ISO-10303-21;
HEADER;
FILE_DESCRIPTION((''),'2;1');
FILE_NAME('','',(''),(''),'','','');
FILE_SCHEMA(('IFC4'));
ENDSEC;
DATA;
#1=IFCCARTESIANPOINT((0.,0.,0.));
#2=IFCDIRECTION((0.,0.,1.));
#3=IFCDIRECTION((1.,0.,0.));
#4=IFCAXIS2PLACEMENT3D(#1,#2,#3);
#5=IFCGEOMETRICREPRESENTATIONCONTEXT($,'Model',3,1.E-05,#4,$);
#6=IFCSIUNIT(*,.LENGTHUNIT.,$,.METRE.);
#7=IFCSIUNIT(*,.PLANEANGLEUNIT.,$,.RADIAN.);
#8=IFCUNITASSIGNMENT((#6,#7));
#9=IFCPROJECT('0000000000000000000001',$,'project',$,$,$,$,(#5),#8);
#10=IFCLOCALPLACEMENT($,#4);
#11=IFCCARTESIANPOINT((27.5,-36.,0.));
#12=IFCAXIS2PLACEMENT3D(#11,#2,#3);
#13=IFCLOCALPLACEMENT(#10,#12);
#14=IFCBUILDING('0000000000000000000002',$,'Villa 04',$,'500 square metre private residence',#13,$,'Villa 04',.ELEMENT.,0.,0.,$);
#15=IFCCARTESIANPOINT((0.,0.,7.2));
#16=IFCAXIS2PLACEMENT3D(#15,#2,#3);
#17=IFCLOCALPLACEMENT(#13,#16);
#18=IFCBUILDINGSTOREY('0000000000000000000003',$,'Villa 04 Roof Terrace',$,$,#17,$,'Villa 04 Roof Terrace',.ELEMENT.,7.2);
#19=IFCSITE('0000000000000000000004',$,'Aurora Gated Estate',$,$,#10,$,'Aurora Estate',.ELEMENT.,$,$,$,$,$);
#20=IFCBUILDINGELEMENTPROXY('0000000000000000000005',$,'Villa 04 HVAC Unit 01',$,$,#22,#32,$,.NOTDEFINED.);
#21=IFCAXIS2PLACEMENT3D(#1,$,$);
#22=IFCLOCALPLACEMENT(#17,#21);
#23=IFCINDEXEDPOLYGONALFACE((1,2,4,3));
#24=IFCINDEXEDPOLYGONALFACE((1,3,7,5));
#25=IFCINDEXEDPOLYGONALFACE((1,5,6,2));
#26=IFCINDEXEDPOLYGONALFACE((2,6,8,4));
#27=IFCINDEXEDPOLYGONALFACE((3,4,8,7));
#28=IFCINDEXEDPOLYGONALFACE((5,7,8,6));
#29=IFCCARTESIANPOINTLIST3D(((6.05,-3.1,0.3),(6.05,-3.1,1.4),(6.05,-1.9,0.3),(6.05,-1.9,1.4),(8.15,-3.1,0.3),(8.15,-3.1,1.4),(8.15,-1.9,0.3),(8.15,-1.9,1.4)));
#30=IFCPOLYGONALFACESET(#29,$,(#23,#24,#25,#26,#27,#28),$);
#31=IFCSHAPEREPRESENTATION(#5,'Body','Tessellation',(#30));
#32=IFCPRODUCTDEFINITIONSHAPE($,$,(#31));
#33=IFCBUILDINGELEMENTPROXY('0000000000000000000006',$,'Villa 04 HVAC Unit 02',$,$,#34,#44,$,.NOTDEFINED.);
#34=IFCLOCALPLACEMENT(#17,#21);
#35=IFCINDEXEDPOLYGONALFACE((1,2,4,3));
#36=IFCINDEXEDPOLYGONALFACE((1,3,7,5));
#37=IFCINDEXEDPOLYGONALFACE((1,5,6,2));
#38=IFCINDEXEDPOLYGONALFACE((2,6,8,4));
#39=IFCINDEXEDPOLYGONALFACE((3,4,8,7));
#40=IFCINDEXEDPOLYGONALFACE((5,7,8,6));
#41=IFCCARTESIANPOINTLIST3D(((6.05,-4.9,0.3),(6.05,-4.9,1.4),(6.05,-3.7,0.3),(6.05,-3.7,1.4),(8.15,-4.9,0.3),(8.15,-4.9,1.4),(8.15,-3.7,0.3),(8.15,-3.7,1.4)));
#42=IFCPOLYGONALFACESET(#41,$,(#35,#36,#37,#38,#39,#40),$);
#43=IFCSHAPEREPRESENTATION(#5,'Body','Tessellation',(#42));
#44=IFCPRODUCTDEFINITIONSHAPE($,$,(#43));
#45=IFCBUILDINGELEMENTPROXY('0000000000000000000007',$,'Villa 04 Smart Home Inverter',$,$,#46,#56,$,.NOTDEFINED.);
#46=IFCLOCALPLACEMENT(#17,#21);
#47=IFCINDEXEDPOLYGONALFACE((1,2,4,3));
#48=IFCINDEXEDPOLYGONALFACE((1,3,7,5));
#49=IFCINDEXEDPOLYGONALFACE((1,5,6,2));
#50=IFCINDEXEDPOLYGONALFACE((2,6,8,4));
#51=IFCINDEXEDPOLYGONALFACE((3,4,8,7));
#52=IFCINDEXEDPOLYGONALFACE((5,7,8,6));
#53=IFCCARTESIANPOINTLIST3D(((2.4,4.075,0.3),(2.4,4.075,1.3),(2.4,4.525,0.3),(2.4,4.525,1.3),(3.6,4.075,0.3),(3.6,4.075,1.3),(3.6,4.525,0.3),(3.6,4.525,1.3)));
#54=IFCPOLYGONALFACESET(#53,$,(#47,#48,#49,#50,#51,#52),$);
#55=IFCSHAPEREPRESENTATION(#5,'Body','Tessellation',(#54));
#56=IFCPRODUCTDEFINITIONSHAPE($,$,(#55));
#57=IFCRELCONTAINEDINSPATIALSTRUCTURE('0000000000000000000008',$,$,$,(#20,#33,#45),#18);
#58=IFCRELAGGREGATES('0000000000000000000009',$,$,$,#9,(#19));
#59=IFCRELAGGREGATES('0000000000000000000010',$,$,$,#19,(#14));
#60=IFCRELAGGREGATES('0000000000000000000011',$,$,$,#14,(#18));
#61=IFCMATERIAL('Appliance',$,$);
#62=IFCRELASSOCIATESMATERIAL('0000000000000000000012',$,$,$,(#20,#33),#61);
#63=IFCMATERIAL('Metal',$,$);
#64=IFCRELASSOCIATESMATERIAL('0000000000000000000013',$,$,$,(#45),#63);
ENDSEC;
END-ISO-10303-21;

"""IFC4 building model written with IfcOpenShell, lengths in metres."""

from ifc_helpers import new_model, si_unit, frame, origin_with_axes, origin_2d_with_axis, place, context, project, spatial, rectangle, extrude, material, element, save


model = new_model("IFC4")

# Units and contexts
model_context = context("Model", 3, precision=1e-05, world=origin_with_axes())
ifc_project = project(units=[si_unit("LENGTHUNIT", "METRE"), si_unit("PLANEANGLEUNIT", "RADIAN")], contexts=[model_context])

# Site, building, storey
site_placement = place(None, origin_with_axes())
site = spatial("IfcSite", under=ifc_project, at=site_placement, Name="Aurora Gated Estate", LongName="Aurora Estate", CompositionType="ELEMENT")
building_placement = place(site_placement, frame((27.5, -36.0, 0.0), z_axis=(0.0, 0.0, 1.0), x_axis=(1.0, 0.0, 0.0)))
building = spatial("IfcBuilding", under=site, at=building_placement, Name="Villa 04", ObjectType="500 square metre private residence", LongName="Villa 04", CompositionType="ELEMENT", ElevationOfRefHeight=0.0, ElevationOfTerrain=0.0)
storey_placement = place(building_placement, frame((0.0, 0.0, 7.2), z_axis=(0.0, 0.0, 1.0), x_axis=(1.0, 0.0, 0.0)))
storey = spatial("IfcBuildingStorey", under=building, at=storey_placement, Name="Villa 04 Roof Terrace", LongName="Villa 04 Roof Terrace", CompositionType="ELEMENT", Elevation=7.2)

# Building element proxies
ifc_material_1 = material(Name="Metal")
ifc_material_2 = material(Name="Appliance")
for number, where, z_axis, x_axis, name in (
    (1, (7.1, -2.5, 0.3), (0.0, 0.0, 1.0), (1.0, 0.0, 0.0), "Villa 04 HVAC Unit 01"),
    (2, (7.1, -4.3, 0.3), (0.0, 0.0, 1.0), (1.0, 0.0, 0.0), "Villa 04 HVAC Unit 02"),
):
    element("IfcBuildingElementProxy", number, at=place(storey_placement, frame(where, z_axis=z_axis, x_axis=x_axis)), inside=storey, material=ifc_material_2, Name=name, PredefinedType="NOTDEFINED", context=model_context, shape_type="SweptSolid", body=[
        extrude(rectangle(XDim=2.1, YDim=1.2, at=origin_2d_with_axis()), origin_with_axes(), (0.0, 0.0, 1.0), 1.1),
    ])
proxy_1_placement = place(storey_placement, frame((3.0, 4.3, 0.3), z_axis=(0.0, 0.0, 1.0), x_axis=(1.0, 0.0, 0.0)))
element("IfcBuildingElementProxy", 3, at=proxy_1_placement, inside=storey, material=ifc_material_1, Name="Villa 04 Smart Home Inverter", PredefinedType="NOTDEFINED", context=model_context, shape_type="SweptSolid", body=[
    extrude(rectangle(XDim=1.2, YDim=0.45, at=origin_2d_with_axis()), origin_with_axes(), (0.0, 0.0, 1.0), 1.0),
])

save(model, "model.ifc")
